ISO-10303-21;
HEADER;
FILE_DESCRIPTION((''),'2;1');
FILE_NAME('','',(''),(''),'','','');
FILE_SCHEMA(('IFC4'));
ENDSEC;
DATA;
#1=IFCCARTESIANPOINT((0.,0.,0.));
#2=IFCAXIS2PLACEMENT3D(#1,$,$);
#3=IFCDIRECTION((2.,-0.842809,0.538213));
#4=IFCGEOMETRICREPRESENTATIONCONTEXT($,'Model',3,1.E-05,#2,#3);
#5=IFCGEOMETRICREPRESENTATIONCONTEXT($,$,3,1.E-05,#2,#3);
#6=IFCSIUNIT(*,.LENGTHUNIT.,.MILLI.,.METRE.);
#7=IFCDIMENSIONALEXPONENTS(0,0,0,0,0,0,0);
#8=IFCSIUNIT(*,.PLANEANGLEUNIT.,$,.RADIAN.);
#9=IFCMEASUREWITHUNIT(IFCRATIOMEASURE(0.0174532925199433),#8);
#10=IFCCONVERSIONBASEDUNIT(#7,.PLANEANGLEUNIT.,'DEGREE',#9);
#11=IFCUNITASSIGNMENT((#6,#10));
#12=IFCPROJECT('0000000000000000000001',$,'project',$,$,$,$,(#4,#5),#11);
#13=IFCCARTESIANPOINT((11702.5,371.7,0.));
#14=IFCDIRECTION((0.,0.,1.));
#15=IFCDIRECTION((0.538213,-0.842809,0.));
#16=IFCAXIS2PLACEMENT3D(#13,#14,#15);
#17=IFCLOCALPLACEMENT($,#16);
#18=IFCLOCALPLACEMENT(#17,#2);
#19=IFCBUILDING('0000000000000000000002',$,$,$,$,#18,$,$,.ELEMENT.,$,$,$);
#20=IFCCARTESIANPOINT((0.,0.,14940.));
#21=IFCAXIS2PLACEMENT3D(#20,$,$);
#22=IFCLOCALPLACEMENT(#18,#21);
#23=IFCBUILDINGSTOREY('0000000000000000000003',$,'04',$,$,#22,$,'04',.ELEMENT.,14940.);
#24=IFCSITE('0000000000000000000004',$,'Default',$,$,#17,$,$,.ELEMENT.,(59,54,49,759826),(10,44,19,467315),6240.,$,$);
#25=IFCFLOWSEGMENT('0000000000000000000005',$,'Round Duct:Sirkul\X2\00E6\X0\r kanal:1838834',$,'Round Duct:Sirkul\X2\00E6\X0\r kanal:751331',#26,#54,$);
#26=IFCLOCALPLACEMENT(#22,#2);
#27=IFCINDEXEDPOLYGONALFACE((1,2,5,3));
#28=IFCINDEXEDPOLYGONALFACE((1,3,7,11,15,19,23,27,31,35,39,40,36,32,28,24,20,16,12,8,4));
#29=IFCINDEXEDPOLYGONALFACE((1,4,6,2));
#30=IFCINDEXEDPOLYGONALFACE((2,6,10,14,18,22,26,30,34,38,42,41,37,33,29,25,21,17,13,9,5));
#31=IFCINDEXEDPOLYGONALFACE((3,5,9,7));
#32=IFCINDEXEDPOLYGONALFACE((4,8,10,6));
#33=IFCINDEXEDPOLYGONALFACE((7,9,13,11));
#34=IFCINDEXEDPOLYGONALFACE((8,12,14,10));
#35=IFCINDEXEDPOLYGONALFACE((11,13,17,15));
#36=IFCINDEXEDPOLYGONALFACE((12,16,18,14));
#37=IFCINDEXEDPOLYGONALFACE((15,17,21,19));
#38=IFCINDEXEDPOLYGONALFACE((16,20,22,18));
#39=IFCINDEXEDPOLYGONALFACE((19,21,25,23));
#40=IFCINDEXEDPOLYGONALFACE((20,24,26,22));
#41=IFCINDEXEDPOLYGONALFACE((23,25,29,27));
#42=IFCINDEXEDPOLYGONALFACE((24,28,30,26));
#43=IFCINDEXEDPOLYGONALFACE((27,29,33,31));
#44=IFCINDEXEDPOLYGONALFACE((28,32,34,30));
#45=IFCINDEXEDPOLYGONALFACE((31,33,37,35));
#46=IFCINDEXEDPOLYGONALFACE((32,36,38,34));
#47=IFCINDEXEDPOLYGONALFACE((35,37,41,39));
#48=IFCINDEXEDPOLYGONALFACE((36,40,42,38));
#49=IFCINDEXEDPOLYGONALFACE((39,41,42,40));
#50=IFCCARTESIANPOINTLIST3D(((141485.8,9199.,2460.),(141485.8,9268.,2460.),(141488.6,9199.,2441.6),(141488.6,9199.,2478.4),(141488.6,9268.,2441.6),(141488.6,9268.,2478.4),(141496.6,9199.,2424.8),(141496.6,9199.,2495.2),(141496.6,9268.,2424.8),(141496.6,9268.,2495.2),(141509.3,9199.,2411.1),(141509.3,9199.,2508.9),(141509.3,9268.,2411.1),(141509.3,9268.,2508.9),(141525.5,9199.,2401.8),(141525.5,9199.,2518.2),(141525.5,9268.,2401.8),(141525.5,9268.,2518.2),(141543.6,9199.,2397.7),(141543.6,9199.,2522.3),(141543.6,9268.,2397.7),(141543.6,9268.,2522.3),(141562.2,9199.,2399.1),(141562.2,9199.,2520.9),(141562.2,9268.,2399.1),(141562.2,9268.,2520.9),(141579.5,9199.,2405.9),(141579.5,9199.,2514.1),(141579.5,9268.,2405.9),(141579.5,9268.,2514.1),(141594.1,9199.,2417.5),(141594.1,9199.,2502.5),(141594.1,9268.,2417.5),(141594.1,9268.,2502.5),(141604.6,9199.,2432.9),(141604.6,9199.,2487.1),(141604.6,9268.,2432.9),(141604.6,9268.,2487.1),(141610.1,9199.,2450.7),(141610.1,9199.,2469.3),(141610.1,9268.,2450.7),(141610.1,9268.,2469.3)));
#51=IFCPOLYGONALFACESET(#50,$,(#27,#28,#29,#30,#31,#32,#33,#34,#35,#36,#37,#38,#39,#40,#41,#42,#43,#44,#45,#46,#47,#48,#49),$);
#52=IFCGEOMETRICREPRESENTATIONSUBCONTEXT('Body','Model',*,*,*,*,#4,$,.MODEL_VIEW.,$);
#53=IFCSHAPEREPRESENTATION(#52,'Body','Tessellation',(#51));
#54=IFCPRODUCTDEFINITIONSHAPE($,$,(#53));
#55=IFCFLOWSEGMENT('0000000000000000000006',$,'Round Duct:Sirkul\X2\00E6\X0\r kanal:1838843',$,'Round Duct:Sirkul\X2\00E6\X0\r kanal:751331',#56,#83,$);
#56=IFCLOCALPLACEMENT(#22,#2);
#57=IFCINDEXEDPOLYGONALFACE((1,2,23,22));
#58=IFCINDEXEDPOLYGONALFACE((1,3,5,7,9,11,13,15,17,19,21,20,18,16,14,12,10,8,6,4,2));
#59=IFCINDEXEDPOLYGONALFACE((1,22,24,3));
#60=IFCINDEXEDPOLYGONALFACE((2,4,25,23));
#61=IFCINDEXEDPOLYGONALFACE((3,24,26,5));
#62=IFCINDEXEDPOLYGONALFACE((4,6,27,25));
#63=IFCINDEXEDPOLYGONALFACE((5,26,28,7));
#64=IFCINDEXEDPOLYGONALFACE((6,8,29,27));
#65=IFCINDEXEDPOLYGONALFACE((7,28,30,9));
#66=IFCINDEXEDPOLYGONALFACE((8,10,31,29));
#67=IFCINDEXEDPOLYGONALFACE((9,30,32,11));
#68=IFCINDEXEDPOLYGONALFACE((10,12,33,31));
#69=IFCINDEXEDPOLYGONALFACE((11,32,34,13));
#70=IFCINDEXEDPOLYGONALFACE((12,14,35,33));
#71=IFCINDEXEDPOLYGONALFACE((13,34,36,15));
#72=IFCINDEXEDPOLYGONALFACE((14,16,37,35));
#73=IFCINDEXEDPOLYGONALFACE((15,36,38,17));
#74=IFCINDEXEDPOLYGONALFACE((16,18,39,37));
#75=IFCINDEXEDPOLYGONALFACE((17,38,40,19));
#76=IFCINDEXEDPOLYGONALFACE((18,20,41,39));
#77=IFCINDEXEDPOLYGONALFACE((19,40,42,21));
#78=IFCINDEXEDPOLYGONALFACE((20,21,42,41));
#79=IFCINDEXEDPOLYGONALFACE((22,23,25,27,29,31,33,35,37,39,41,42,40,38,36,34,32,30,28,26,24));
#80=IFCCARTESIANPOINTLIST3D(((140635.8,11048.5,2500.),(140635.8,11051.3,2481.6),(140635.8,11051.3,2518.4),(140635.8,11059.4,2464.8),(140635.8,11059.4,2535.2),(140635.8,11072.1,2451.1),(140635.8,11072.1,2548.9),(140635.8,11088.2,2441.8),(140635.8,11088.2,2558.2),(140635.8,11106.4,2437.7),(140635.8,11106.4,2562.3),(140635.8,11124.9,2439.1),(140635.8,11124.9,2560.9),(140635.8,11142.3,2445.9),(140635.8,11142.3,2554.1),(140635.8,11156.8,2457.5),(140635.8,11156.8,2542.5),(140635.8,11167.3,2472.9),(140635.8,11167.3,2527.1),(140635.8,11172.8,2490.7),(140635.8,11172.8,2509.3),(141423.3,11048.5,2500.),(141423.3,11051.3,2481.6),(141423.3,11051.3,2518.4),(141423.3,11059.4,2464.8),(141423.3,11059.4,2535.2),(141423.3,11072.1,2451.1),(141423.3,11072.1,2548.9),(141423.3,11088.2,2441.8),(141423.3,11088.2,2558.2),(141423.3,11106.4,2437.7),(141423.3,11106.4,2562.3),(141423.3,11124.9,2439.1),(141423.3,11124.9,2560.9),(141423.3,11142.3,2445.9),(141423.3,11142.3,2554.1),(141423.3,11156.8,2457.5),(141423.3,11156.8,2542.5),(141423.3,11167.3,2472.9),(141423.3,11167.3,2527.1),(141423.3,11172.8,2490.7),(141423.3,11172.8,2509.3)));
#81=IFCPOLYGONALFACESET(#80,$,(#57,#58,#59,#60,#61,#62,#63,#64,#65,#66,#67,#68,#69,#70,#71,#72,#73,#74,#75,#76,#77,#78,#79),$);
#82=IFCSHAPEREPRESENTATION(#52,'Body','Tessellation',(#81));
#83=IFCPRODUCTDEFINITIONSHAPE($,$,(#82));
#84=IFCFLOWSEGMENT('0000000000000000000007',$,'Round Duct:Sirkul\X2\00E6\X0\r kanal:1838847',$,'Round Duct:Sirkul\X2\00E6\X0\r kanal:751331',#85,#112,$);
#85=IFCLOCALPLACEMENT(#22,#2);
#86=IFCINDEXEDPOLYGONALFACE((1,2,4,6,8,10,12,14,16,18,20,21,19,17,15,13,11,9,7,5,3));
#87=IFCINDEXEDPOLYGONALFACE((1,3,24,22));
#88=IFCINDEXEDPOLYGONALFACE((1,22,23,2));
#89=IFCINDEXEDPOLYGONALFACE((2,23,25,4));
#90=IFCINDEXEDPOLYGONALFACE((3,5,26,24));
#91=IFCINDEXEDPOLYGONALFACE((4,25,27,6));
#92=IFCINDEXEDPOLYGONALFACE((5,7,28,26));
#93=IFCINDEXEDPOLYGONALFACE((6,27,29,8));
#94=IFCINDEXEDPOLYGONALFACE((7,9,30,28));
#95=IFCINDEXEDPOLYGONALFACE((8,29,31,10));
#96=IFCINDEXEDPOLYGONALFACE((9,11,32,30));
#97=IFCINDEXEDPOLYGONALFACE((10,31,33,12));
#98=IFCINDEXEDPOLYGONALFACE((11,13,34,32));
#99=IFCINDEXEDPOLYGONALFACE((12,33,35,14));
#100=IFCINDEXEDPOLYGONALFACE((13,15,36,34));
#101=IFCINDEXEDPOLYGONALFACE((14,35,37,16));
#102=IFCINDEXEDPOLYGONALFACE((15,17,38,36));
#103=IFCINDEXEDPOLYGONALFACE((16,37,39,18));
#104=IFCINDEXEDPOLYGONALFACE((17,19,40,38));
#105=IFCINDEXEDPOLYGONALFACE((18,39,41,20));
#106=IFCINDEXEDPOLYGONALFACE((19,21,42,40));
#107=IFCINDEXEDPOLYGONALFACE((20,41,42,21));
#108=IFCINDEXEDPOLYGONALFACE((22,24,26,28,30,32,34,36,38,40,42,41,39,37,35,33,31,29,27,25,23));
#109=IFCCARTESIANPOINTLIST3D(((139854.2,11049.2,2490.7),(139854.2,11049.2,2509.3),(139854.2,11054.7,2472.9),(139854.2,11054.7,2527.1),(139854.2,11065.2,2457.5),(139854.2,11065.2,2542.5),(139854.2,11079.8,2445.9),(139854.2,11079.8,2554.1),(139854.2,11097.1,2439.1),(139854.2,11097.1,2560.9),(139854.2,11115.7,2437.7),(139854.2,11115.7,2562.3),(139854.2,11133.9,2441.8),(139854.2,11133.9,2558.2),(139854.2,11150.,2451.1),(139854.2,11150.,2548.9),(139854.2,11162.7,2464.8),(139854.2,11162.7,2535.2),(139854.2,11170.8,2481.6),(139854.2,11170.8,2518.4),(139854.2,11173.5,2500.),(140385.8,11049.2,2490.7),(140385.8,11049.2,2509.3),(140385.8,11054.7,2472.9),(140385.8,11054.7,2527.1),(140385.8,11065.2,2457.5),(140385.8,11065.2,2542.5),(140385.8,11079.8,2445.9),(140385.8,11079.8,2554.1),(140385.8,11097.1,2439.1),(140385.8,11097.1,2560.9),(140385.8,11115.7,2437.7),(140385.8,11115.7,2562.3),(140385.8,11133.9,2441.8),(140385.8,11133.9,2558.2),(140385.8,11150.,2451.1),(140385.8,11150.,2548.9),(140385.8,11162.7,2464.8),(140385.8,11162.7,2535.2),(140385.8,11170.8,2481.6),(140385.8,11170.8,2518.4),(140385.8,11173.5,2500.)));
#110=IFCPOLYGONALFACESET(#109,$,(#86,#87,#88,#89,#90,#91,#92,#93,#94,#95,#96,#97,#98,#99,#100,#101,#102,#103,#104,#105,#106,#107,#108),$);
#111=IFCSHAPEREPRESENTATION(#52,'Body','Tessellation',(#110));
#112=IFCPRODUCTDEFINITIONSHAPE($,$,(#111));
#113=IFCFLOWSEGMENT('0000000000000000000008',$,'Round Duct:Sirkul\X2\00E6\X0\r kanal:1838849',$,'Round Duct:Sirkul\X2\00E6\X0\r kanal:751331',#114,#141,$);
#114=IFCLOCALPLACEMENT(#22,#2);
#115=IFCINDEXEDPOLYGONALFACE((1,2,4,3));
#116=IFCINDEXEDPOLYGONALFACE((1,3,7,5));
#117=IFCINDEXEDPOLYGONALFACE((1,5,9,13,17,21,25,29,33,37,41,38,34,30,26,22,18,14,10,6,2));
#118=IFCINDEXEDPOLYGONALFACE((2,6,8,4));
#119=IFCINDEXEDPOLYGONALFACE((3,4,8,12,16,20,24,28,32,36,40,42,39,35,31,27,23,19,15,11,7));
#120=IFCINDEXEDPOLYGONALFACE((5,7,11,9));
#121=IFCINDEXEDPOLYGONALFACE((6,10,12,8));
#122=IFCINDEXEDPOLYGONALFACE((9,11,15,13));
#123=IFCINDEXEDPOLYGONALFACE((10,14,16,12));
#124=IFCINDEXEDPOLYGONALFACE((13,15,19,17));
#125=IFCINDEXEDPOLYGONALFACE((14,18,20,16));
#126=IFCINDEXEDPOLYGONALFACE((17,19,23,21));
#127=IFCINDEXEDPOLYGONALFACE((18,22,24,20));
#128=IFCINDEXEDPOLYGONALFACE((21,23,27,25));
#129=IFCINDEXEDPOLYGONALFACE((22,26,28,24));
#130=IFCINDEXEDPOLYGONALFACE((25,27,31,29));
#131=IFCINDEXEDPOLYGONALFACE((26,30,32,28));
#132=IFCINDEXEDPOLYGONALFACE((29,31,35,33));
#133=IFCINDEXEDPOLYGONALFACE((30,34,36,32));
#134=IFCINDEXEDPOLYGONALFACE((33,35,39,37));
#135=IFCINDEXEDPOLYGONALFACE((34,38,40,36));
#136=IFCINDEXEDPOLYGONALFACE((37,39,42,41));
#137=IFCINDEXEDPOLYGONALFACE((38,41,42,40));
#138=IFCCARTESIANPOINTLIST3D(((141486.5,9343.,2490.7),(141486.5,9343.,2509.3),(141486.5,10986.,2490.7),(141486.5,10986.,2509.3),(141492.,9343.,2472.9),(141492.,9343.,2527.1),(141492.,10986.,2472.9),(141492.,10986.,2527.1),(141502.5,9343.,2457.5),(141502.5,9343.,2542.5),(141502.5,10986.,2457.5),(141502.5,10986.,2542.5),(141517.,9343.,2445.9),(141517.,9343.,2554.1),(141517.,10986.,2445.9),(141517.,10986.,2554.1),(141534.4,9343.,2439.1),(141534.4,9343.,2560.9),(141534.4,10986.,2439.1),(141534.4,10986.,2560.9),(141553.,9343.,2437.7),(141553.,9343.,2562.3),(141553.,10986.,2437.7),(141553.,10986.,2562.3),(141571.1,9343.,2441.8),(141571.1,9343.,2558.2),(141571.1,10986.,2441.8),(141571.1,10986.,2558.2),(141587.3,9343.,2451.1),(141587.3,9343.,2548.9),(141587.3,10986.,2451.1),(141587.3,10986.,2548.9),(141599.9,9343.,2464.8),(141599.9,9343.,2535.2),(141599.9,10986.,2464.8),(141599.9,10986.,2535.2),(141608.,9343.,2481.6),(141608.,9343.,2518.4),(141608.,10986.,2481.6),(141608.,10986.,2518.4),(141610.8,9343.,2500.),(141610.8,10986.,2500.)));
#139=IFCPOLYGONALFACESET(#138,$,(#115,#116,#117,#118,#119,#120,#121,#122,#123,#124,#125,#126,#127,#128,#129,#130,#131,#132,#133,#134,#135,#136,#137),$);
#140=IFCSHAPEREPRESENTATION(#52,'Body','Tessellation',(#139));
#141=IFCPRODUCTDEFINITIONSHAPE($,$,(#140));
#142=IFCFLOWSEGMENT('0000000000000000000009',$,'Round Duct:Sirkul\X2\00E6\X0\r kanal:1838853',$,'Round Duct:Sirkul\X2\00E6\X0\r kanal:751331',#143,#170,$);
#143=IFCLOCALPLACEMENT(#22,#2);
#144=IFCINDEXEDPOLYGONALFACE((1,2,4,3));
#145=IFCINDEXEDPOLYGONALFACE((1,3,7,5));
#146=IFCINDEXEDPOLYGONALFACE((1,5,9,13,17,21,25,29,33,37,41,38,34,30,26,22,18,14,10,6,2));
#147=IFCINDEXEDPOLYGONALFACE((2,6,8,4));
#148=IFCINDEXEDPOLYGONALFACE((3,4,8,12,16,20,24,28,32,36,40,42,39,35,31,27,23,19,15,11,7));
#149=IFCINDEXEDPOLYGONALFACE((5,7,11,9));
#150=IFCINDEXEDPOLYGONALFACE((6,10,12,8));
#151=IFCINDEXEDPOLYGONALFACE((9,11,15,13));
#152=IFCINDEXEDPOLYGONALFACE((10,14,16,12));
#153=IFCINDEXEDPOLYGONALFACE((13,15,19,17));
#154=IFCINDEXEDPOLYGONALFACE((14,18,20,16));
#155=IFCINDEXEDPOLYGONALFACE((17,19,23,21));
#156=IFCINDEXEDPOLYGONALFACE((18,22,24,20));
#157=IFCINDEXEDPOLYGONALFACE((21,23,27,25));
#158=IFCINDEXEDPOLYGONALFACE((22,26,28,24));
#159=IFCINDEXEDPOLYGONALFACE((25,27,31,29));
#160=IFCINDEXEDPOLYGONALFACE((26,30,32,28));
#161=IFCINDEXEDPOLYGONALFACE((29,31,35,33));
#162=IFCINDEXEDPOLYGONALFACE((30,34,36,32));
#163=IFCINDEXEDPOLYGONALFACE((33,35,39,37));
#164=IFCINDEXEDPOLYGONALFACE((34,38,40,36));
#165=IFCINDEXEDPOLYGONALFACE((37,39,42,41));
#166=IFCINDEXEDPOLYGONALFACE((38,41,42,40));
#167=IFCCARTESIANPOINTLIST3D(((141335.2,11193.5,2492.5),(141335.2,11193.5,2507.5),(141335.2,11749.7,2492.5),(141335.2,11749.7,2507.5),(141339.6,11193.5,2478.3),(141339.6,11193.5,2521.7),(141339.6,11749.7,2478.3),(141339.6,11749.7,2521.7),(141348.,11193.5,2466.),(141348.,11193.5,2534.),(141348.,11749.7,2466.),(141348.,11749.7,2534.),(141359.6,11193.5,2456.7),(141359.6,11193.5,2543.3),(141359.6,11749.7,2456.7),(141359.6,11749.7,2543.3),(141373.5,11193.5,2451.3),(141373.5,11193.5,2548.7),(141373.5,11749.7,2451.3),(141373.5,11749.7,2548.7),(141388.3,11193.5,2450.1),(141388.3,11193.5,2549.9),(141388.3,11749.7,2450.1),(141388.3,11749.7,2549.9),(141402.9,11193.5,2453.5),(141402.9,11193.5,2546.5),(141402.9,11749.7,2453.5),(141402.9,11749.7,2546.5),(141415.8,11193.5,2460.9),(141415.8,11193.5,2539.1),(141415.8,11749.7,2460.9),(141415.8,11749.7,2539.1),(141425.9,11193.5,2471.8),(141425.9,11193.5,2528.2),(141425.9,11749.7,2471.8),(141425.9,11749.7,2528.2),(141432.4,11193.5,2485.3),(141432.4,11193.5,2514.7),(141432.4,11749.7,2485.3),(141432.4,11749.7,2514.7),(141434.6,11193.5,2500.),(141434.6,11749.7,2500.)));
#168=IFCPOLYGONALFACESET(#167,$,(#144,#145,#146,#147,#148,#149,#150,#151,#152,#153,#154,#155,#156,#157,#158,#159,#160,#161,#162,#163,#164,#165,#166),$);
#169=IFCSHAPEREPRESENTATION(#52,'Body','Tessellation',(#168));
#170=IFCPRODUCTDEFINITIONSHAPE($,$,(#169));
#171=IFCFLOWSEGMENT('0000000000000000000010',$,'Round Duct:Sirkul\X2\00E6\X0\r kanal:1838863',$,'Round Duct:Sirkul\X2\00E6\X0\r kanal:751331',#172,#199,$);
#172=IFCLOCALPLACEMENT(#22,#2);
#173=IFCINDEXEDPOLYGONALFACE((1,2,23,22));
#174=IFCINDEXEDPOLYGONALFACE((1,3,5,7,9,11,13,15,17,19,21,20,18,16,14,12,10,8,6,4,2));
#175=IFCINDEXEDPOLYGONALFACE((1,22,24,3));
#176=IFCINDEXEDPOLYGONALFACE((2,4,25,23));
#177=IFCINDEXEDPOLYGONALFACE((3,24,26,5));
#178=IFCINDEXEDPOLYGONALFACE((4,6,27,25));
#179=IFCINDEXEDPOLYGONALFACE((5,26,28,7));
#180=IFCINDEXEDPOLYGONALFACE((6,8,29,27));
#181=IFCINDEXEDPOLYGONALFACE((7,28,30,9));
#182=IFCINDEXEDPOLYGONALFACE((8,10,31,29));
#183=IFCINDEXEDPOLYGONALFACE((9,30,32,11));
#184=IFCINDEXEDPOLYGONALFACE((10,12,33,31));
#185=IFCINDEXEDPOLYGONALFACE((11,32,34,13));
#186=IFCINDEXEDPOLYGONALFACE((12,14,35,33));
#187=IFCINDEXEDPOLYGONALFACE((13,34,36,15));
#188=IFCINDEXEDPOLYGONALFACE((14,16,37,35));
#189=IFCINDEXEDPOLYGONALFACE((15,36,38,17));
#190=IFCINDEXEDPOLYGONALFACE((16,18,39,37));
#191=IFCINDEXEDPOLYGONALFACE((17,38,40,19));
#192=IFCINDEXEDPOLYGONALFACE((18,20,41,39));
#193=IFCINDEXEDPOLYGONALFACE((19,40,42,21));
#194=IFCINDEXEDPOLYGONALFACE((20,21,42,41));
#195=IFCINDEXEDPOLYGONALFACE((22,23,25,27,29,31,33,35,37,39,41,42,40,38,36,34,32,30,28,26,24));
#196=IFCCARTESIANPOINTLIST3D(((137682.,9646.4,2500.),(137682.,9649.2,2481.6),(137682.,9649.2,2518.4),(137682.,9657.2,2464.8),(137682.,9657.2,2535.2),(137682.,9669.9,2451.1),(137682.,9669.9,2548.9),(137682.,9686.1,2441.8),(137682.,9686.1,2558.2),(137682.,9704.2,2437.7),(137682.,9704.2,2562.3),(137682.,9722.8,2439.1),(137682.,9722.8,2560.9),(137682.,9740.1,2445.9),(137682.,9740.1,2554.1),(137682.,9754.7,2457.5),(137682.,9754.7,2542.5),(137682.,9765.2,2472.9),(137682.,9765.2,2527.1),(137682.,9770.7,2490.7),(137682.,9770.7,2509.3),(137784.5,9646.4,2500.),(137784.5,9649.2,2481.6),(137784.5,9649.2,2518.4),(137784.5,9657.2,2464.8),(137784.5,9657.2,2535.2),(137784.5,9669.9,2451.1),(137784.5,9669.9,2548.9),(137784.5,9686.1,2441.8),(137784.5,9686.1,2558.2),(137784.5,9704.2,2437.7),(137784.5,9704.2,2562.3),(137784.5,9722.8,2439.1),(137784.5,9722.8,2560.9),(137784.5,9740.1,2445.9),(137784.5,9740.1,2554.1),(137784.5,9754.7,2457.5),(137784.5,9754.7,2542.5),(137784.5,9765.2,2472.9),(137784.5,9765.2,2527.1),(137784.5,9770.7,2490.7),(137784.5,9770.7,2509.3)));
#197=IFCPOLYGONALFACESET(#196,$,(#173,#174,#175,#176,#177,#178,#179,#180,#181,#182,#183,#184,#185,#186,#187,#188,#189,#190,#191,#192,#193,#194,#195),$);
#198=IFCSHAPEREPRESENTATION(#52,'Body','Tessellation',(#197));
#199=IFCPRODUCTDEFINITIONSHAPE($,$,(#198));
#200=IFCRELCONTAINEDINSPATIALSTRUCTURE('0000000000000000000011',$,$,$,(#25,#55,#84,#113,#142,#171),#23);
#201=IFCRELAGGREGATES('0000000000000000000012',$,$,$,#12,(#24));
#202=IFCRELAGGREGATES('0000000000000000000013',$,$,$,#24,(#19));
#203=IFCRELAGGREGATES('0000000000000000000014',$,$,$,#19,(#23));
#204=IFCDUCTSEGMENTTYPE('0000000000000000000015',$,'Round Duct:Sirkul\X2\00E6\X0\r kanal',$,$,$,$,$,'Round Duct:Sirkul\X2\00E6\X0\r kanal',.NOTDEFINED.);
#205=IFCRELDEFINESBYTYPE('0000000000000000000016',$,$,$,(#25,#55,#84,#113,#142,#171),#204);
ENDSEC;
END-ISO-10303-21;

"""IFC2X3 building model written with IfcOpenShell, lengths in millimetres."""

from ifc_helpers import new_model, entity, si_unit, converted_unit, direction, frame, frame_2d, origin, origin_2d_with_axis, place, context, subcontext, project, spatial, circle, extrude, type_object, element, save


model = new_model("IFC2X3")

# Units and contexts
model_context = context("Model", 3, precision=1e-05, world=origin(), true_north=direction((2.0, -0.842809, 0.538213)))
context_of_model = context(None, 3, precision=1e-05, world=origin(), true_north=direction((2.0, -0.842809, 0.538213)))
body_context = subcontext(model_context, "Body", "Model", "MODEL_VIEW")
ifc_project = project(units=[si_unit("LENGTHUNIT", "METRE", prefix="MILLI"), converted_unit("PLANEANGLEUNIT", "DEGREE", entity("IfcRatioMeasure", 0.0174532925199433), si_unit("PLANEANGLEUNIT", "RADIAN"), dimensions=[0, 0, 0, 0, 0, 0, 0])], contexts=[model_context, context_of_model])

# Site, building, storey
site_placement = place(None, frame((11702.5, 371.7, 0.0), z_axis=(0.0, 0.0, 1.0), x_axis=(0.538213, -0.842809, 0.0)))
site = spatial("IfcSite", under=ifc_project, at=site_placement, Name="Default", CompositionType="ELEMENT", RefLatitude=(59, 54, 49, 759826), RefLongitude=(10, 44, 19, 467315), RefElevation=6240.0)
building_placement = place(site_placement, origin())
building = spatial("IfcBuilding", under=site, at=building_placement, CompositionType="ELEMENT")
storey_placement = place(building_placement, frame((0.0, 0.0, 14940.0)))
storey = spatial("IfcBuildingStorey", under=building, at=storey_placement, Name="04", LongName="04", CompositionType="ELEMENT", Elevation=14940.0)

# Flow segments
duct_segment_type_1 = type_object("IfcDuctSegmentType", Name="Round Duct:Sirkulær kanal", ElementType="Round Duct:Sirkulær kanal", PredefinedType="NOTDEFINED")
flow_segment_1_placement = place(storey_placement, origin())
element("IfcFlowSegment", 1, at=flow_segment_1_placement, inside=storey, type_object=duct_segment_type_1, Name="Round Duct:Sirkulær kanal:1838834", ObjectType="Round Duct:Sirkulær kanal:751331", context=body_context, shape_type="SweptSolid", body=[
    extrude(circle(Radius=62.5, at=origin_2d_with_axis()), frame((141548.3, 9199.0, 2460.0), z_axis=(0.0, 1.0, 0.0), x_axis=(-1.0, 0.0, 0.0)), (0.0, 0.0, 1.0), 69.0),
])
flow_segment_2_placement = place(storey_placement, origin())
element("IfcFlowSegment", 2, at=flow_segment_2_placement, inside=storey, type_object=duct_segment_type_1, Name="Round Duct:Sirkulær kanal:1838843", ObjectType="Round Duct:Sirkulær kanal:751331", context=body_context, shape_type="SweptSolid", body=[
    extrude(circle(Radius=62.5, at=frame_2d((0.0, 0.0), x_axis=(1.0, 0.0))), frame((140635.8, 11111.0, 2500.0), z_axis=(1.0, 0.0, 0.0), x_axis=(0.0, -1.0, 0.0)), (0.0, 0.0, 1.0), 787.5),
])
flow_segment_3_placement = place(storey_placement, origin())
element("IfcFlowSegment", 3, at=flow_segment_3_placement, inside=storey, type_object=duct_segment_type_1, Name="Round Duct:Sirkulær kanal:1838847", ObjectType="Round Duct:Sirkulær kanal:751331", context=body_context, shape_type="SweptSolid", body=[
    extrude(circle(Radius=62.5, at=frame_2d((0.0, 0.0), x_axis=(1.0, 0.0))), frame((139854.2, 11111.0, 2500.0), z_axis=(1.0, 0.0, 0.0), x_axis=(0.0, 1.0, 0.0)), (0.0, 0.0, 1.0), 531.6),
])
flow_segment_4_placement = place(storey_placement, origin())
element("IfcFlowSegment", 4, at=flow_segment_4_placement, inside=storey, type_object=duct_segment_type_1, Name="Round Duct:Sirkulær kanal:1838849", ObjectType="Round Duct:Sirkulær kanal:751331", context=body_context, shape_type="SweptSolid", body=[
    extrude(circle(Radius=62.5, at=origin_2d_with_axis()), frame((141548.3, 9343.0, 2500.0), z_axis=(0.0, 1.0, 0.0), x_axis=(1.0, 0.0, 0.0)), (0.0, 0.0, 1.0), 1643.0),
])
flow_segment_5_placement = place(storey_placement, origin())
element("IfcFlowSegment", 5, at=flow_segment_5_placement, inside=storey, type_object=duct_segment_type_1, Name="Round Duct:Sirkulær kanal:1838853", ObjectType="Round Duct:Sirkulær kanal:751331", context=body_context, shape_type="SweptSolid", body=[
    extrude(circle(Radius=50.0, at=origin_2d_with_axis()), frame((141384.6, 11193.5, 2500.0), z_axis=(0.0, 1.0, 0.0), x_axis=(1.0, 0.0, 0.0)), (0.0, 0.0, 1.0), 556.2),
])
flow_segment_6_placement = place(storey_placement, origin())
element("IfcFlowSegment", 6, at=flow_segment_6_placement, inside=storey, type_object=duct_segment_type_1, Name="Round Duct:Sirkulær kanal:1838863", ObjectType="Round Duct:Sirkulær kanal:751331", context=body_context, shape_type="SweptSolid", body=[
    extrude(circle(Radius=62.5, at=frame_2d((0.0, 0.0), x_axis=(1.0, 0.0))), frame((137682.0, 9708.9, 2500.0), z_axis=(1.0, 0.0, 0.0), x_axis=(0.0, -1.0, 0.0)), (0.0, 0.0, 1.0), 102.5),
])

save(model, "model.ifc")
